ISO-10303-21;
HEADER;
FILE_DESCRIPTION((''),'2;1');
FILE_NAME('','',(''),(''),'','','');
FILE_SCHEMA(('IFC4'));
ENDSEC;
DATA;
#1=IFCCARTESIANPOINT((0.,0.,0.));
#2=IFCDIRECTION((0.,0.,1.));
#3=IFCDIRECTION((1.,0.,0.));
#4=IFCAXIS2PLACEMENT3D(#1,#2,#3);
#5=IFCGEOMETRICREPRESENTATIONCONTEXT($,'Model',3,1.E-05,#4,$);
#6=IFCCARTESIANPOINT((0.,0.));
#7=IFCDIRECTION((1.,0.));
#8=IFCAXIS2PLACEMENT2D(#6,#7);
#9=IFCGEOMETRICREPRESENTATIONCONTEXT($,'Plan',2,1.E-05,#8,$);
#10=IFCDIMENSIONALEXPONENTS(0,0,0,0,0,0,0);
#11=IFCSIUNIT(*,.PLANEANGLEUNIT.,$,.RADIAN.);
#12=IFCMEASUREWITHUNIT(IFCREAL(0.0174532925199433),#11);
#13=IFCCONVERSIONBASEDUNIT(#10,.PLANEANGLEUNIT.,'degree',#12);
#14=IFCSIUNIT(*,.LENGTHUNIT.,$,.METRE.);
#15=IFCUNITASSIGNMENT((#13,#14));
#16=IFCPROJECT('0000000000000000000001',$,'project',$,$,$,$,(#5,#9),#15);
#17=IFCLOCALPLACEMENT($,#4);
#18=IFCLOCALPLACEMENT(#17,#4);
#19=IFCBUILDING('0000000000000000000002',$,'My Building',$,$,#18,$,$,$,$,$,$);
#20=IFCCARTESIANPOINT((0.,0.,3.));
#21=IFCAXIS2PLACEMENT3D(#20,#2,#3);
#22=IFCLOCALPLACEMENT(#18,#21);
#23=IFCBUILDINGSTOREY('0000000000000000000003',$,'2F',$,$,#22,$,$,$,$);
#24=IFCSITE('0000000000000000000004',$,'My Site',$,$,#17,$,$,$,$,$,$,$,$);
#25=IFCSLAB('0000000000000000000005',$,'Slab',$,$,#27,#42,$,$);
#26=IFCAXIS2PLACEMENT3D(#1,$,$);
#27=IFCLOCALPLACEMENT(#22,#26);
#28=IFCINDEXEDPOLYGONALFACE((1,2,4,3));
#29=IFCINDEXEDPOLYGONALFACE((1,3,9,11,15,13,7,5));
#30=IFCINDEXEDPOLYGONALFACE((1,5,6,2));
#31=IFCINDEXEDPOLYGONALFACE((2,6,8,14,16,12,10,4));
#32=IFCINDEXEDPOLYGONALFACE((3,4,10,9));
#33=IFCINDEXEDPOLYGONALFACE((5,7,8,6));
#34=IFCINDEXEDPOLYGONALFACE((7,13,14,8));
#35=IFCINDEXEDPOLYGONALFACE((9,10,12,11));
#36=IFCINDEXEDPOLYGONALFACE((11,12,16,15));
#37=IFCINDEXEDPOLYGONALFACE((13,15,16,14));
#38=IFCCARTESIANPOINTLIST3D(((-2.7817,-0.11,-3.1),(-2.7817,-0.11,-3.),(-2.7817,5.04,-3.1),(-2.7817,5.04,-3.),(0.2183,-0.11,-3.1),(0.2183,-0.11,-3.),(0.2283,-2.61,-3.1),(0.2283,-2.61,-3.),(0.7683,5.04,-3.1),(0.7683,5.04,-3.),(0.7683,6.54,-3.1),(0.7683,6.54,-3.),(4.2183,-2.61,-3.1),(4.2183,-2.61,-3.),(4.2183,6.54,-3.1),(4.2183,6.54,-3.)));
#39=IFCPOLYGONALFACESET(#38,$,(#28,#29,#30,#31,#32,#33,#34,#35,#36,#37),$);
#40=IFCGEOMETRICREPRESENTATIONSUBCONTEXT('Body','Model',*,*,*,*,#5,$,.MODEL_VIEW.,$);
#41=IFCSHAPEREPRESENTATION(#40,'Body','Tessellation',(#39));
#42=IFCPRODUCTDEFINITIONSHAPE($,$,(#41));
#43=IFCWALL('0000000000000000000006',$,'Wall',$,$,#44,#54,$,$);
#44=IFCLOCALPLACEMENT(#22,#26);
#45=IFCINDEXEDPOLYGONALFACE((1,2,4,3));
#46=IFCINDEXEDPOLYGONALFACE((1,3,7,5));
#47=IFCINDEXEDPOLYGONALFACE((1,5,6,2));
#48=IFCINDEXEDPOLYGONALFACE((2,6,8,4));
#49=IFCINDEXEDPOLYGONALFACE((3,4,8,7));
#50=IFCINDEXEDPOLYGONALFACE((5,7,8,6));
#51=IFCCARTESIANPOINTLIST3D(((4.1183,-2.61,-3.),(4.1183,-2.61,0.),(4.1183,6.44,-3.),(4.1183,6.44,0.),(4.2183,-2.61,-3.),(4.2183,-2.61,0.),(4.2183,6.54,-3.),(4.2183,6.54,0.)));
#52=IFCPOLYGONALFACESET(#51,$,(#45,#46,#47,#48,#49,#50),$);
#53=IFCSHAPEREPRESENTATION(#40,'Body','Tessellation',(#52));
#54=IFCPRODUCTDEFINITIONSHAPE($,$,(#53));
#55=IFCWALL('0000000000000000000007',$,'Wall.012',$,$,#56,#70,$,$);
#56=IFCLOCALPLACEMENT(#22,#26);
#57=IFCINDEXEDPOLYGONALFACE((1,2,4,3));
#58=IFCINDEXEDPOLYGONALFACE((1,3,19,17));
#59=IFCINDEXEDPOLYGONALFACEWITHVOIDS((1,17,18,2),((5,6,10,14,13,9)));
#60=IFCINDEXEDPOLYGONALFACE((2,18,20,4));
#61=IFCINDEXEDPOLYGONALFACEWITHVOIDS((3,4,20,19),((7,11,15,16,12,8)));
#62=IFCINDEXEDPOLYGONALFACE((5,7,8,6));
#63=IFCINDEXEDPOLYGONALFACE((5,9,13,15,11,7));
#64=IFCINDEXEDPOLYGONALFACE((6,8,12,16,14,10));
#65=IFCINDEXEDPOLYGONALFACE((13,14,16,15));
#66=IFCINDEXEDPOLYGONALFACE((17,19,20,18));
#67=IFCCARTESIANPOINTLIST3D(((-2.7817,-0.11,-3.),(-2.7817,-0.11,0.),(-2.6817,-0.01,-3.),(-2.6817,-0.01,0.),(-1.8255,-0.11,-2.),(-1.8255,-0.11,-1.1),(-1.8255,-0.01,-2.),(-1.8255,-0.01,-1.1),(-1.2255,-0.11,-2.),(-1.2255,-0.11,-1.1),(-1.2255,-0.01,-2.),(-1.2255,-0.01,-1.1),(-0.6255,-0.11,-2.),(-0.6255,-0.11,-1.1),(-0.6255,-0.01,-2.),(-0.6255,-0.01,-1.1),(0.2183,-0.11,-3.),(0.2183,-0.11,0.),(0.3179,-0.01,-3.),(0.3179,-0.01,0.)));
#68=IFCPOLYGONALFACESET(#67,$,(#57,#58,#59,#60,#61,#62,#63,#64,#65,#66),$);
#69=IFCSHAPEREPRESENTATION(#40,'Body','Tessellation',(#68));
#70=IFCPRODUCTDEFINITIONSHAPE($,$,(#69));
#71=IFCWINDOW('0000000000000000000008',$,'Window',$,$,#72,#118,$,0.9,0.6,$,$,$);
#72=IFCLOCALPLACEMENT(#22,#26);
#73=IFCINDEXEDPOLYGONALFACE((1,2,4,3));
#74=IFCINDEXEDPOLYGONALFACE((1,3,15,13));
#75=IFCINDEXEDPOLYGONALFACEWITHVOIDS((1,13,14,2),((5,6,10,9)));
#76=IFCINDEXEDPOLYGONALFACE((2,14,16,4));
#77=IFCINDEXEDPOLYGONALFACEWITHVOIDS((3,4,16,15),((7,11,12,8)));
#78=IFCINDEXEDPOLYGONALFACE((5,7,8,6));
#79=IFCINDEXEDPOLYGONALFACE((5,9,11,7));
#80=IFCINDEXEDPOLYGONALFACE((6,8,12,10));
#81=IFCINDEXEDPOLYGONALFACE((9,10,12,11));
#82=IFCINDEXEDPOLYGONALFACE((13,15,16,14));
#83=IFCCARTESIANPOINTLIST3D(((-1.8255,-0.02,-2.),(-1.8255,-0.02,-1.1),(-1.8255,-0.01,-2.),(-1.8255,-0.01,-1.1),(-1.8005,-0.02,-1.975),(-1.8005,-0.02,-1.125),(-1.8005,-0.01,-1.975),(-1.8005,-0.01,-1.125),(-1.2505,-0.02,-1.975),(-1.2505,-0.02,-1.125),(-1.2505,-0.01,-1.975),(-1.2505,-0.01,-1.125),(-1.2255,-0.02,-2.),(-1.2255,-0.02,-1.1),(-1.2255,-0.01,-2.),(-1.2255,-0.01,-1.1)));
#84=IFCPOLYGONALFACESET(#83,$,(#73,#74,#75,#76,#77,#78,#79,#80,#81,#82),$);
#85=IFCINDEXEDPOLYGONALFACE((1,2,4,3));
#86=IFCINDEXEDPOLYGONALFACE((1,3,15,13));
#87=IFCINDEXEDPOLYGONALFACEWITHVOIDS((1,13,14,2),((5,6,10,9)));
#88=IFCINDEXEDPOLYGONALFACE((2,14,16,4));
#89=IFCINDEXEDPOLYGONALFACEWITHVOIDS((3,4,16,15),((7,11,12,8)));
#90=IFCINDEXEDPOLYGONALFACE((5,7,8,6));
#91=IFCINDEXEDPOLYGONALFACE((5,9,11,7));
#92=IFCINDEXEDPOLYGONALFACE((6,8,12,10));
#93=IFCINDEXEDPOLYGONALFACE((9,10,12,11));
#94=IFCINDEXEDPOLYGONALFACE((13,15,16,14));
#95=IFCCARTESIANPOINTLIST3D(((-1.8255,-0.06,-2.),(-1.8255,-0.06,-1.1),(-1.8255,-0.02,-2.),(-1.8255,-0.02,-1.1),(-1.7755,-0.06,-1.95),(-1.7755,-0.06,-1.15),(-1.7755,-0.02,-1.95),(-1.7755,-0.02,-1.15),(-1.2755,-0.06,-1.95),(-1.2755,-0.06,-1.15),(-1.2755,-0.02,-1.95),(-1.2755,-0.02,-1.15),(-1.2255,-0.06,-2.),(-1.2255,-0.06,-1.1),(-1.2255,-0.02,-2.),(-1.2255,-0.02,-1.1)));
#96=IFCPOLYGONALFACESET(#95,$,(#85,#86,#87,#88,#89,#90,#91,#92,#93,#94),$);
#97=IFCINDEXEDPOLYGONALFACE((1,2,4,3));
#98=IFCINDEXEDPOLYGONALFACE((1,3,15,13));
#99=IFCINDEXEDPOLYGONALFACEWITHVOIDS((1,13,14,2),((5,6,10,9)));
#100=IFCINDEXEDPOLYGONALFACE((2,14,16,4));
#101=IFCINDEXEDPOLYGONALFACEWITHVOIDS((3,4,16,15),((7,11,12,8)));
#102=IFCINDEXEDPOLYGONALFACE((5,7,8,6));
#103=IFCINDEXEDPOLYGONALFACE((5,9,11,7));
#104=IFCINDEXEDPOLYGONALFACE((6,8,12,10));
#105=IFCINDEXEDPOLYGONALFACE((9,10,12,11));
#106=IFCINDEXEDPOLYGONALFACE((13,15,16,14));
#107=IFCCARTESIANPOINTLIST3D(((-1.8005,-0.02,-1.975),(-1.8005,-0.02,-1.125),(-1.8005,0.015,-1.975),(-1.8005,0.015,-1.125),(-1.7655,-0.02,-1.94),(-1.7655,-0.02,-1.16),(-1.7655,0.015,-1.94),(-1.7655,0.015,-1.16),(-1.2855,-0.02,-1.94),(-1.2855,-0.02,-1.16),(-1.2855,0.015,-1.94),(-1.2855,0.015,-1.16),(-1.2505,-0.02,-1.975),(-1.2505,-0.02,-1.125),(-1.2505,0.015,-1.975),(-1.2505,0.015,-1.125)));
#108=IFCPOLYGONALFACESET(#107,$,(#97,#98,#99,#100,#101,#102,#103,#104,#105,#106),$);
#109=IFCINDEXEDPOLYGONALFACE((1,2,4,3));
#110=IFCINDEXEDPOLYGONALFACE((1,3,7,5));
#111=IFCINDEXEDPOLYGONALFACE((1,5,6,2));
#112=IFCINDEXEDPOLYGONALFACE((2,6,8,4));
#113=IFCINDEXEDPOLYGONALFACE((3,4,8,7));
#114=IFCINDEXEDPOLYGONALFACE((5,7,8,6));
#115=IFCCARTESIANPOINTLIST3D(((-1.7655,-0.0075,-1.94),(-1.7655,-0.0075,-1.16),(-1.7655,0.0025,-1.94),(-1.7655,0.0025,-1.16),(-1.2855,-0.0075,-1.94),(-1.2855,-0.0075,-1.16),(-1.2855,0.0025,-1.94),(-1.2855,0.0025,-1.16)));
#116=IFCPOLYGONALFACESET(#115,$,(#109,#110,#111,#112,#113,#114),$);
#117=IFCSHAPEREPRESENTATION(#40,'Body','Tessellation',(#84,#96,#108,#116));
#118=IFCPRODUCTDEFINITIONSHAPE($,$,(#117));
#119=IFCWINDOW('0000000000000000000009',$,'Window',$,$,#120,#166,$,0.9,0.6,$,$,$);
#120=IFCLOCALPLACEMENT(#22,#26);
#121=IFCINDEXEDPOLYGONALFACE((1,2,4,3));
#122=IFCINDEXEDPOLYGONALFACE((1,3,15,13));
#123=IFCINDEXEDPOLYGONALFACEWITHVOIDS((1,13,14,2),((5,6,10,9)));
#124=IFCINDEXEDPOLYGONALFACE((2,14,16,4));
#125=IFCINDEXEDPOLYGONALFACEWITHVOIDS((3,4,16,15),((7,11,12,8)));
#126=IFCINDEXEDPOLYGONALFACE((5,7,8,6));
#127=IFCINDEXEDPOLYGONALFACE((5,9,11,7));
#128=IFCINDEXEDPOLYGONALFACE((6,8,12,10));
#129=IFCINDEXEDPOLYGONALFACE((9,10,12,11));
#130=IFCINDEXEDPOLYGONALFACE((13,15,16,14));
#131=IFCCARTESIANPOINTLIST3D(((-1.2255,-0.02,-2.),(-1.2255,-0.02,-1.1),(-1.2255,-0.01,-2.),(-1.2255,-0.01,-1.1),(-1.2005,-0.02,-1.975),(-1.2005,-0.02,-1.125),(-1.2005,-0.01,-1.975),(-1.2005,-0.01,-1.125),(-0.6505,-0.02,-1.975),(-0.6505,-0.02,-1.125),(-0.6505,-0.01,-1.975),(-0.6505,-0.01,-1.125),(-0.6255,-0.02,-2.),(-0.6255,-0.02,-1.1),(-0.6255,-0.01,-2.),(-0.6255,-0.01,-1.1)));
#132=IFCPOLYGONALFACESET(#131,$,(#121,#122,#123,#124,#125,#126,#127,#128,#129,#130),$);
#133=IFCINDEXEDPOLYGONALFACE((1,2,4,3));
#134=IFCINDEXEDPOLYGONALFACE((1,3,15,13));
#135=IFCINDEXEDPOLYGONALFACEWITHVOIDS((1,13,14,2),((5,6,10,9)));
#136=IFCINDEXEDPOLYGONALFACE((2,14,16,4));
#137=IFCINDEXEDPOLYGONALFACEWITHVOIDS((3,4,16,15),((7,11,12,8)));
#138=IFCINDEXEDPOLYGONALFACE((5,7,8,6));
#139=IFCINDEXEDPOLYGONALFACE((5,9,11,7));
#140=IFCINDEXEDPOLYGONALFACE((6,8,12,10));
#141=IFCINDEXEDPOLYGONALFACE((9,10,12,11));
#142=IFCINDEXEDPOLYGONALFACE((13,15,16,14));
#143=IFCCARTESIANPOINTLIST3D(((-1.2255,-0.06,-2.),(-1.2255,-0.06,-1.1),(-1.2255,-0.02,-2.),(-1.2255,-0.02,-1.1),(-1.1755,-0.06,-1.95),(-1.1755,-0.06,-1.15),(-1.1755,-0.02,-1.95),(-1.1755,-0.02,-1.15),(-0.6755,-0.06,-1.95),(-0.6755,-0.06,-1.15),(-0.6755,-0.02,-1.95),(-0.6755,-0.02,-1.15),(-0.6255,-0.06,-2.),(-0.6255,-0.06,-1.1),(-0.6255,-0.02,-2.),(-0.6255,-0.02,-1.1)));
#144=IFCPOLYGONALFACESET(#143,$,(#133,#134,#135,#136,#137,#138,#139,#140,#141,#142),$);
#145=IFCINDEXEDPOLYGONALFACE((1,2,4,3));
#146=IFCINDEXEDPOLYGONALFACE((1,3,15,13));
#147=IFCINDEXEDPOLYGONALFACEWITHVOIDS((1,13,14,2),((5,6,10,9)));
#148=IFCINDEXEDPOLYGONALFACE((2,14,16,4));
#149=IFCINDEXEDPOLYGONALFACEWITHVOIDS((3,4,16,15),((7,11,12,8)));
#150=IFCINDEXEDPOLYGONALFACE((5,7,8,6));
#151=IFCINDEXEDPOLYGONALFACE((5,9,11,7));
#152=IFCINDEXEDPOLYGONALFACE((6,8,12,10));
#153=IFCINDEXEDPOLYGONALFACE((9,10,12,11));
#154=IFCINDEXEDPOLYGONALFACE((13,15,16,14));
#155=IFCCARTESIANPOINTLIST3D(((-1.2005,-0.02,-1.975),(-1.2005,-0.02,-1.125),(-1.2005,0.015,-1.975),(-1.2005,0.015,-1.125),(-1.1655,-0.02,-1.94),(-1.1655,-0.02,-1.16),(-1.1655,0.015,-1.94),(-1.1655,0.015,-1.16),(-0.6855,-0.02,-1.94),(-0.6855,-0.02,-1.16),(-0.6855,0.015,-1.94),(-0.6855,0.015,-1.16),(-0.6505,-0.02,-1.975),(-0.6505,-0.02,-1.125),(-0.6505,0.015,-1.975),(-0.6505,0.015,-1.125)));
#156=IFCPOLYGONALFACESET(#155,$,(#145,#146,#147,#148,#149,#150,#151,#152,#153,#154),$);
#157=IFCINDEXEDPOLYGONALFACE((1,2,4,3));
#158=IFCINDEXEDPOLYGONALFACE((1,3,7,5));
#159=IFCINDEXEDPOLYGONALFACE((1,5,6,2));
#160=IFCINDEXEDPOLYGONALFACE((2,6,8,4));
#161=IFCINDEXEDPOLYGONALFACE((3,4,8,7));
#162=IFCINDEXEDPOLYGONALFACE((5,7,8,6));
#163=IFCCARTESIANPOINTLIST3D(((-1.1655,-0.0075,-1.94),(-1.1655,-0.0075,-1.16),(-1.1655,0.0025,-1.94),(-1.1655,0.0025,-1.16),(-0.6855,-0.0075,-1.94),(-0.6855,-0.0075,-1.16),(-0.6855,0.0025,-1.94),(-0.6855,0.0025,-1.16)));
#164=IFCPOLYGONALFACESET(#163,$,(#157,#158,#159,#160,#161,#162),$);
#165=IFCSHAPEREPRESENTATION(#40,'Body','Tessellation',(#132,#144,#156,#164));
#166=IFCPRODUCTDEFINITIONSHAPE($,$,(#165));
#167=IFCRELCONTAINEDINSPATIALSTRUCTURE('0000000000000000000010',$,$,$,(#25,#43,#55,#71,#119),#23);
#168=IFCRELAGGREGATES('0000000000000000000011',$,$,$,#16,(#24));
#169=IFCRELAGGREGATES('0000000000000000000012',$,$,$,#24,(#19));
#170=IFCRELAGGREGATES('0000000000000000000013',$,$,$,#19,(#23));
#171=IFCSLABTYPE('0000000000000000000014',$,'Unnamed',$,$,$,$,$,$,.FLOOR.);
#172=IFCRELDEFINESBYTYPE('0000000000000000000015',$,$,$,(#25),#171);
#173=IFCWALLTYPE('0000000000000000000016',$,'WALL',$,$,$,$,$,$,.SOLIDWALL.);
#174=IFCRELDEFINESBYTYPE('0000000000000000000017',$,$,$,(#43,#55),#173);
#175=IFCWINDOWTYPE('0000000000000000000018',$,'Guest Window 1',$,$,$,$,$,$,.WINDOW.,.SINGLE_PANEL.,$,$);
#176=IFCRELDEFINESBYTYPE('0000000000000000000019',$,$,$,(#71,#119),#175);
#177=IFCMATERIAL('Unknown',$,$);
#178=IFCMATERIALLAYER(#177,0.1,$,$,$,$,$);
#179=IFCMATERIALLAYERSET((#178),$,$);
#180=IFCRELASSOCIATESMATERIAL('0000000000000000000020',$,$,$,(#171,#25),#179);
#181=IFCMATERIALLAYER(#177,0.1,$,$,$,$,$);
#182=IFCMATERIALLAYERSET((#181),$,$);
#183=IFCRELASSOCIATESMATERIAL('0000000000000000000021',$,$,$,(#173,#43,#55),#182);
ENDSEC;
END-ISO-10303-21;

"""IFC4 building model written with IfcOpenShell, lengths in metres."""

from ifc_helpers import new_model, entity, si_unit, converted_unit, frame, origin_with_axes, origin_2d_with_axis, place, context, subcontext, project, spatial, line, indexed_curve, outline, extrude, shape, source, transform, mapped, material, layer, layer_set, layer_usage, type_object, type_shapes, element, fill, save


model = new_model("IFC4")

# Units and contexts
model_context = context("Model", 3, precision=1e-05, world=origin_with_axes())
plan_context = context("Plan", 2, precision=1e-05, world=origin_2d_with_axis())
body_context_1 = subcontext(model_context, "Body", "Model", "MODEL_VIEW")
body_context_2 = subcontext(plan_context, "Body", "Plan", "PLAN_VIEW")
ifc_project = project(units=[converted_unit("PLANEANGLEUNIT", "degree", entity("IfcReal", 0.0174532925199433), si_unit("PLANEANGLEUNIT", "RADIAN"), dimensions=[0, 0, 0, 0, 0, 0, 0]), si_unit("LENGTHUNIT", "METRE")], contexts=[model_context, plan_context])

# Site, building, storey
site_placement = place(None, origin_with_axes())
site = spatial("IfcSite", under=ifc_project, at=site_placement, Name="My Site")
building_placement = place(site_placement, origin_with_axes())
building = spatial("IfcBuilding", under=site, at=building_placement, Name="My Building")
storey_placement = place(building_placement, frame((0.0, 0.0, 3.0), z_axis=(0.0, 0.0, 1.0), x_axis=(1.0, 0.0, 0.0)))
storey = spatial("IfcBuildingStorey", under=building, at=storey_placement, Name="2F")

# Slab
ifc_material = material(Name="Unknown")
ifc_layer_1 = layer(ifc_material, 0.1)
ifc_layer_set_1 = layer_set([ifc_layer_1])
ifc_layer_usage_1 = layer_usage(ifc_layer_set_1, "AXIS3", "POSITIVE", -0.1)
slab_type = type_object("IfcSlabType", Name="Unnamed", PredefinedType="FLOOR", material=ifc_layer_set_1)
slab_placement = place(storey_placement, frame((4.2183, -2.61, -3.0), z_axis=(0.0, 0.0, 1.0), x_axis=(1.0, 0.0, 0.0)))
element("IfcSlab", 1, at=slab_placement, inside=storey, type_object=slab_type, material=ifc_layer_usage_1, Name="Slab", context=body_context_1, shape_type="SweptSolid", body=[
    extrude(outline(indexed_curve([(0.0, 0.0), (0.0, 9.15), (-3.45, 9.15), (-3.45, 7.65), (-7.0, 7.65), (-7.0, 2.5), (-4.0, 2.5), (-3.99, 0.0), (0.0, 0.0)])), frame((0.0, 0.0, -0.1), z_axis=(0.0, 0.0, 1.0), x_axis=(1.0, 0.0, 0.0)), (0.0, 0.0, 1.0), 0.1),
])

# Wall
ifc_layer_2 = layer(ifc_material, 0.1)
ifc_layer_set_2 = layer_set([ifc_layer_2])
ifc_layer_usage_2 = layer_usage(ifc_layer_set_2, "AXIS2", "POSITIVE", 0.0)
wall_type_1 = type_object("IfcWallType", Name="WALL", PredefinedType="SOLIDWALL", material=ifc_layer_set_2)
wall_1_placement = place(storey_placement, frame((4.2183, -2.61, -3.0), z_axis=(0.0, 0.0, 1.0), x_axis=(0.0, 1.0, 0.0)))
element("IfcWall", 2, at=wall_1_placement, inside=storey, type_object=wall_type_1, material=ifc_layer_usage_2, Name="Wall", context=body_context_1, shape_type="SweptSolid", body=[
    extrude(outline(indexed_curve([(0.0, 0.0), (0.0, 0.1), (9.05, 0.1), (9.15, 0.0)], segments=[line(1, 2, 3, 4, 1)])), origin_with_axes(), (0.0, 0.0, 1.0), 3.0),
])

# Wall, openings, windows
ifc_layer_usage_3 = layer_usage(ifc_layer_set_2, "AXIS2", "POSITIVE", 0.0)
wall_2_placement = place(storey_placement, frame((-2.7817, -0.11, -3.0), z_axis=(0.0, 0.0, 1.0), x_axis=(1.0, 0.0, 0.0)))
wall_2 = element("IfcWall", 3, at=wall_2_placement, inside=storey, type_object=wall_type_1, material=ifc_layer_usage_3, Name="Wall.012", context=body_context_1, shape_type="SweptSolid", body=[
    extrude(outline(indexed_curve([(0.0, 0.0), (0.1, 0.1), (3.0996, 0.1), (3.0, 0.0)], segments=[line(1, 2, 3, 4, 1)])), origin_with_axes(), (0.0, 0.0, 1.0), 3.0),
])
shared_shape_1 = source(origin_with_axes(), body_context_1, "Body", "SweptSolid", [
    extrude(outline(indexed_curve([(0.0, 0.0), (0.6, 0.0), (0.6, 0.9), (0.0, 0.9)], segments=[line(1, 2, 3, 4, 1)])), frame((0.0, -0.6, 0.0), z_axis=(0.0, -1.0, 0.0), x_axis=(1.0, 0.0, 0.0)), (0.0, 0.0, -1.0), 1.2),
])
opening_1_placement = place(wall_2_placement, frame((0.9562, 0.0, 1.0), z_axis=(0.0, 0.0, 1.0), x_axis=(1.0, 0.0, 0.0)))
opening_1 = element("IfcOpeningElement", 4, at=opening_1_placement, cuts=wall_2, PredefinedType="OPENING", context=body_context_1, shape_type="MappedRepresentation", body=[
    mapped(shared_shape_1, transform((0.0, 0.0, 0.0), x_axis=(1.0, 0.0, 0.0), y_axis=(0.0, 1.0, 0.0), z_axis=(0.0, 0.0, 1.0), scale=1.0)),
])
opening_2_placement = place(wall_2_placement, frame((1.5562, 0.0, 1.0), z_axis=(0.0, 0.0, 1.0), x_axis=(1.0, 0.0, 0.0)))
opening_2 = element("IfcOpeningElement", 5, at=opening_2_placement, cuts=wall_2, PredefinedType="OPENING", context=body_context_1, shape_type="MappedRepresentation", body=[
    mapped(shared_shape_1, transform((0.0, 0.0, 0.0), x_axis=(1.0, 0.0, 0.0), y_axis=(0.0, 1.0, 0.0), z_axis=(0.0, 0.0, 1.0), scale=1.0)),
])
window_type_1 = type_object("IfcWindowType", Name="Guest Window 1", PartitioningType="SINGLE_PANEL", PredefinedType="WINDOW")
shared_shape_2 = source(origin_with_axes(), body_context_1, "Body", "SweptSolid", [
    extrude(outline(indexed_curve([(0.0, 0.0), (0.6, 0.0), (0.6, 0.9), (0.0, 0.9)], segments=[line(1, 2, 3, 4, 1)]), holes=[indexed_curve([(0.025, 0.025), (0.575, 0.025), (0.575, 0.875), (0.025, 0.875)], segments=[line(1, 2, 3, 4, 1)])]), frame((0.0, 0.09, 0.0), z_axis=(0.0, -1.0, 0.0), x_axis=(1.0, 0.0, 0.0)), (0.0, 0.0, -1.0), 0.01),
    extrude(outline(indexed_curve([(0.0, 0.0), (0.6, 0.0), (0.6, 0.9), (0.0, 0.9)], segments=[line(1, 2, 3, 4, 1)]), holes=[indexed_curve([(0.05, 0.05), (0.55, 0.05), (0.55, 0.85), (0.05, 0.85)], segments=[line(1, 2, 3, 4, 1)])]), frame((0.0, 0.05, 0.0), z_axis=(0.0, -1.0, 0.0), x_axis=(1.0, 0.0, 0.0)), (0.0, 0.0, -1.0), 0.04),
    extrude(outline(indexed_curve([(0.0, 0.0), (0.55, 0.0), (0.55, 0.85), (0.0, 0.85)], segments=[line(1, 2, 3, 4, 1)]), holes=[indexed_curve([(0.035, 0.035), (0.515, 0.035), (0.515, 0.815), (0.035, 0.815)], segments=[line(1, 2, 3, 4, 1)])]), frame((0.025, 0.09, 0.025), z_axis=(0.0, -1.0, 0.0), x_axis=(1.0, 0.0, 0.0)), (0.0, 0.0, -1.0), 0.035),
    extrude(outline(indexed_curve([(0.035, 0.035), (0.515, 0.035), (0.515, 0.815), (0.035, 0.815)], segments=[line(1, 2, 3, 4, 1)])), frame((0.025, 0.1025, 0.025), z_axis=(0.0, -1.0, 0.0), x_axis=(1.0, 0.0, 0.0)), (0.0, 0.0, -1.0), 0.01),
])
shared_shape_3 = source(origin_with_axes(), body_context_2, "Body", "Curve2D", [
    entity("IfcIndexedPolyCurve", entity("IfcCartesianPointList2D", [[0.05, 0.05], [0.55, 0.05]])),
    entity("IfcIndexedPolyCurve", entity("IfcCartesianPointList2D", [[0.0, 0.1], [0.025, 0.1], [0.025, 0.09], [0.05, 0.09], [0.05, 0.05], [0.0, 0.05]]), [entity("IfcLineIndex", [1, 2, 3, 4, 5, 6, 1])]),
    entity("IfcIndexedPolyCurve", entity("IfcCartesianPointList2D", [[0.6, 0.1], [0.575, 0.1], [0.575, 0.09], [0.55, 0.09], [0.55, 0.05], [0.6, 0.05]]), [entity("IfcLineIndex", [1, 2, 3, 4, 5, 6, 1])]),
    entity("IfcIndexedPolyCurve", entity("IfcCartesianPointList2D", [[0.025, 0.09], [0.06, 0.09], [0.06, 0.125], [0.025, 0.125]]), [entity("IfcLineIndex", [1, 2, 3, 4, 1])]),
    entity("IfcIndexedPolyCurve", entity("IfcCartesianPointList2D", [[0.575, 0.09], [0.54, 0.09], [0.54, 0.125], [0.575, 0.125]]), [entity("IfcLineIndex", [1, 2, 3, 4, 1])]),
    entity("IfcIndexedPolyCurve", entity("IfcCartesianPointList2D", [[0.06, 0.09], [0.54, 0.09]])),
    entity("IfcIndexedPolyCurve", entity("IfcCartesianPointList2D", [[0.06, 0.125], [0.54, 0.125]])),
    entity("IfcIndexedPolyCurve", entity("IfcCartesianPointList2D", [[0.06, 0.1075], [0.54, 0.1075]])),
])
type_shapes(window_type_1, [shared_shape_2, shared_shape_3])
window_1_placement = place(opening_1_placement, origin_with_axes())
window_1 = element("IfcWindow", 6, at=window_1_placement, inside=storey, type_object=window_type_1, Name="Window", OverallHeight=0.9, OverallWidth=0.6, shapes=[
    shape(body_context_1, "Body", "MappedRepresentation", [mapped(shared_shape_2, transform((0.0, 0.0, 0.0), x_axis=(1.0, 0.0, 0.0), y_axis=(0.0, 1.0, 0.0), z_axis=(0.0, 0.0, 1.0), scale=1.0))]),
    shape(body_context_2, "Body", "MappedRepresentation", [mapped(shared_shape_3, transform((0.0, 0.0, 0.0), x_axis=(1.0, 0.0, 0.0), y_axis=(0.0, 1.0, 0.0), z_axis=(0.0, 0.0, 1.0), scale=1.0))]),
])
fill(opening_1, window_1)
window_2_placement = place(opening_2_placement, origin_with_axes())
window_2 = element("IfcWindow", 7, at=window_2_placement, inside=storey, type_object=window_type_1, Name="Window", OverallHeight=0.9, OverallWidth=0.6, shapes=[
    shape(body_context_1, "Body", "MappedRepresentation", [mapped(shared_shape_2, transform((0.0, 0.0, 0.0), x_axis=(1.0, 0.0, 0.0), y_axis=(0.0, 1.0, 0.0), z_axis=(0.0, 0.0, 1.0), scale=1.0))]),
    shape(body_context_2, "Body", "MappedRepresentation", [mapped(shared_shape_3, transform((0.0, 0.0, 0.0), x_axis=(1.0, 0.0, 0.0), y_axis=(0.0, 1.0, 0.0), z_axis=(0.0, 0.0, 1.0), scale=1.0))]),
])
fill(opening_2, window_2)

save(model, "model.ifc")
